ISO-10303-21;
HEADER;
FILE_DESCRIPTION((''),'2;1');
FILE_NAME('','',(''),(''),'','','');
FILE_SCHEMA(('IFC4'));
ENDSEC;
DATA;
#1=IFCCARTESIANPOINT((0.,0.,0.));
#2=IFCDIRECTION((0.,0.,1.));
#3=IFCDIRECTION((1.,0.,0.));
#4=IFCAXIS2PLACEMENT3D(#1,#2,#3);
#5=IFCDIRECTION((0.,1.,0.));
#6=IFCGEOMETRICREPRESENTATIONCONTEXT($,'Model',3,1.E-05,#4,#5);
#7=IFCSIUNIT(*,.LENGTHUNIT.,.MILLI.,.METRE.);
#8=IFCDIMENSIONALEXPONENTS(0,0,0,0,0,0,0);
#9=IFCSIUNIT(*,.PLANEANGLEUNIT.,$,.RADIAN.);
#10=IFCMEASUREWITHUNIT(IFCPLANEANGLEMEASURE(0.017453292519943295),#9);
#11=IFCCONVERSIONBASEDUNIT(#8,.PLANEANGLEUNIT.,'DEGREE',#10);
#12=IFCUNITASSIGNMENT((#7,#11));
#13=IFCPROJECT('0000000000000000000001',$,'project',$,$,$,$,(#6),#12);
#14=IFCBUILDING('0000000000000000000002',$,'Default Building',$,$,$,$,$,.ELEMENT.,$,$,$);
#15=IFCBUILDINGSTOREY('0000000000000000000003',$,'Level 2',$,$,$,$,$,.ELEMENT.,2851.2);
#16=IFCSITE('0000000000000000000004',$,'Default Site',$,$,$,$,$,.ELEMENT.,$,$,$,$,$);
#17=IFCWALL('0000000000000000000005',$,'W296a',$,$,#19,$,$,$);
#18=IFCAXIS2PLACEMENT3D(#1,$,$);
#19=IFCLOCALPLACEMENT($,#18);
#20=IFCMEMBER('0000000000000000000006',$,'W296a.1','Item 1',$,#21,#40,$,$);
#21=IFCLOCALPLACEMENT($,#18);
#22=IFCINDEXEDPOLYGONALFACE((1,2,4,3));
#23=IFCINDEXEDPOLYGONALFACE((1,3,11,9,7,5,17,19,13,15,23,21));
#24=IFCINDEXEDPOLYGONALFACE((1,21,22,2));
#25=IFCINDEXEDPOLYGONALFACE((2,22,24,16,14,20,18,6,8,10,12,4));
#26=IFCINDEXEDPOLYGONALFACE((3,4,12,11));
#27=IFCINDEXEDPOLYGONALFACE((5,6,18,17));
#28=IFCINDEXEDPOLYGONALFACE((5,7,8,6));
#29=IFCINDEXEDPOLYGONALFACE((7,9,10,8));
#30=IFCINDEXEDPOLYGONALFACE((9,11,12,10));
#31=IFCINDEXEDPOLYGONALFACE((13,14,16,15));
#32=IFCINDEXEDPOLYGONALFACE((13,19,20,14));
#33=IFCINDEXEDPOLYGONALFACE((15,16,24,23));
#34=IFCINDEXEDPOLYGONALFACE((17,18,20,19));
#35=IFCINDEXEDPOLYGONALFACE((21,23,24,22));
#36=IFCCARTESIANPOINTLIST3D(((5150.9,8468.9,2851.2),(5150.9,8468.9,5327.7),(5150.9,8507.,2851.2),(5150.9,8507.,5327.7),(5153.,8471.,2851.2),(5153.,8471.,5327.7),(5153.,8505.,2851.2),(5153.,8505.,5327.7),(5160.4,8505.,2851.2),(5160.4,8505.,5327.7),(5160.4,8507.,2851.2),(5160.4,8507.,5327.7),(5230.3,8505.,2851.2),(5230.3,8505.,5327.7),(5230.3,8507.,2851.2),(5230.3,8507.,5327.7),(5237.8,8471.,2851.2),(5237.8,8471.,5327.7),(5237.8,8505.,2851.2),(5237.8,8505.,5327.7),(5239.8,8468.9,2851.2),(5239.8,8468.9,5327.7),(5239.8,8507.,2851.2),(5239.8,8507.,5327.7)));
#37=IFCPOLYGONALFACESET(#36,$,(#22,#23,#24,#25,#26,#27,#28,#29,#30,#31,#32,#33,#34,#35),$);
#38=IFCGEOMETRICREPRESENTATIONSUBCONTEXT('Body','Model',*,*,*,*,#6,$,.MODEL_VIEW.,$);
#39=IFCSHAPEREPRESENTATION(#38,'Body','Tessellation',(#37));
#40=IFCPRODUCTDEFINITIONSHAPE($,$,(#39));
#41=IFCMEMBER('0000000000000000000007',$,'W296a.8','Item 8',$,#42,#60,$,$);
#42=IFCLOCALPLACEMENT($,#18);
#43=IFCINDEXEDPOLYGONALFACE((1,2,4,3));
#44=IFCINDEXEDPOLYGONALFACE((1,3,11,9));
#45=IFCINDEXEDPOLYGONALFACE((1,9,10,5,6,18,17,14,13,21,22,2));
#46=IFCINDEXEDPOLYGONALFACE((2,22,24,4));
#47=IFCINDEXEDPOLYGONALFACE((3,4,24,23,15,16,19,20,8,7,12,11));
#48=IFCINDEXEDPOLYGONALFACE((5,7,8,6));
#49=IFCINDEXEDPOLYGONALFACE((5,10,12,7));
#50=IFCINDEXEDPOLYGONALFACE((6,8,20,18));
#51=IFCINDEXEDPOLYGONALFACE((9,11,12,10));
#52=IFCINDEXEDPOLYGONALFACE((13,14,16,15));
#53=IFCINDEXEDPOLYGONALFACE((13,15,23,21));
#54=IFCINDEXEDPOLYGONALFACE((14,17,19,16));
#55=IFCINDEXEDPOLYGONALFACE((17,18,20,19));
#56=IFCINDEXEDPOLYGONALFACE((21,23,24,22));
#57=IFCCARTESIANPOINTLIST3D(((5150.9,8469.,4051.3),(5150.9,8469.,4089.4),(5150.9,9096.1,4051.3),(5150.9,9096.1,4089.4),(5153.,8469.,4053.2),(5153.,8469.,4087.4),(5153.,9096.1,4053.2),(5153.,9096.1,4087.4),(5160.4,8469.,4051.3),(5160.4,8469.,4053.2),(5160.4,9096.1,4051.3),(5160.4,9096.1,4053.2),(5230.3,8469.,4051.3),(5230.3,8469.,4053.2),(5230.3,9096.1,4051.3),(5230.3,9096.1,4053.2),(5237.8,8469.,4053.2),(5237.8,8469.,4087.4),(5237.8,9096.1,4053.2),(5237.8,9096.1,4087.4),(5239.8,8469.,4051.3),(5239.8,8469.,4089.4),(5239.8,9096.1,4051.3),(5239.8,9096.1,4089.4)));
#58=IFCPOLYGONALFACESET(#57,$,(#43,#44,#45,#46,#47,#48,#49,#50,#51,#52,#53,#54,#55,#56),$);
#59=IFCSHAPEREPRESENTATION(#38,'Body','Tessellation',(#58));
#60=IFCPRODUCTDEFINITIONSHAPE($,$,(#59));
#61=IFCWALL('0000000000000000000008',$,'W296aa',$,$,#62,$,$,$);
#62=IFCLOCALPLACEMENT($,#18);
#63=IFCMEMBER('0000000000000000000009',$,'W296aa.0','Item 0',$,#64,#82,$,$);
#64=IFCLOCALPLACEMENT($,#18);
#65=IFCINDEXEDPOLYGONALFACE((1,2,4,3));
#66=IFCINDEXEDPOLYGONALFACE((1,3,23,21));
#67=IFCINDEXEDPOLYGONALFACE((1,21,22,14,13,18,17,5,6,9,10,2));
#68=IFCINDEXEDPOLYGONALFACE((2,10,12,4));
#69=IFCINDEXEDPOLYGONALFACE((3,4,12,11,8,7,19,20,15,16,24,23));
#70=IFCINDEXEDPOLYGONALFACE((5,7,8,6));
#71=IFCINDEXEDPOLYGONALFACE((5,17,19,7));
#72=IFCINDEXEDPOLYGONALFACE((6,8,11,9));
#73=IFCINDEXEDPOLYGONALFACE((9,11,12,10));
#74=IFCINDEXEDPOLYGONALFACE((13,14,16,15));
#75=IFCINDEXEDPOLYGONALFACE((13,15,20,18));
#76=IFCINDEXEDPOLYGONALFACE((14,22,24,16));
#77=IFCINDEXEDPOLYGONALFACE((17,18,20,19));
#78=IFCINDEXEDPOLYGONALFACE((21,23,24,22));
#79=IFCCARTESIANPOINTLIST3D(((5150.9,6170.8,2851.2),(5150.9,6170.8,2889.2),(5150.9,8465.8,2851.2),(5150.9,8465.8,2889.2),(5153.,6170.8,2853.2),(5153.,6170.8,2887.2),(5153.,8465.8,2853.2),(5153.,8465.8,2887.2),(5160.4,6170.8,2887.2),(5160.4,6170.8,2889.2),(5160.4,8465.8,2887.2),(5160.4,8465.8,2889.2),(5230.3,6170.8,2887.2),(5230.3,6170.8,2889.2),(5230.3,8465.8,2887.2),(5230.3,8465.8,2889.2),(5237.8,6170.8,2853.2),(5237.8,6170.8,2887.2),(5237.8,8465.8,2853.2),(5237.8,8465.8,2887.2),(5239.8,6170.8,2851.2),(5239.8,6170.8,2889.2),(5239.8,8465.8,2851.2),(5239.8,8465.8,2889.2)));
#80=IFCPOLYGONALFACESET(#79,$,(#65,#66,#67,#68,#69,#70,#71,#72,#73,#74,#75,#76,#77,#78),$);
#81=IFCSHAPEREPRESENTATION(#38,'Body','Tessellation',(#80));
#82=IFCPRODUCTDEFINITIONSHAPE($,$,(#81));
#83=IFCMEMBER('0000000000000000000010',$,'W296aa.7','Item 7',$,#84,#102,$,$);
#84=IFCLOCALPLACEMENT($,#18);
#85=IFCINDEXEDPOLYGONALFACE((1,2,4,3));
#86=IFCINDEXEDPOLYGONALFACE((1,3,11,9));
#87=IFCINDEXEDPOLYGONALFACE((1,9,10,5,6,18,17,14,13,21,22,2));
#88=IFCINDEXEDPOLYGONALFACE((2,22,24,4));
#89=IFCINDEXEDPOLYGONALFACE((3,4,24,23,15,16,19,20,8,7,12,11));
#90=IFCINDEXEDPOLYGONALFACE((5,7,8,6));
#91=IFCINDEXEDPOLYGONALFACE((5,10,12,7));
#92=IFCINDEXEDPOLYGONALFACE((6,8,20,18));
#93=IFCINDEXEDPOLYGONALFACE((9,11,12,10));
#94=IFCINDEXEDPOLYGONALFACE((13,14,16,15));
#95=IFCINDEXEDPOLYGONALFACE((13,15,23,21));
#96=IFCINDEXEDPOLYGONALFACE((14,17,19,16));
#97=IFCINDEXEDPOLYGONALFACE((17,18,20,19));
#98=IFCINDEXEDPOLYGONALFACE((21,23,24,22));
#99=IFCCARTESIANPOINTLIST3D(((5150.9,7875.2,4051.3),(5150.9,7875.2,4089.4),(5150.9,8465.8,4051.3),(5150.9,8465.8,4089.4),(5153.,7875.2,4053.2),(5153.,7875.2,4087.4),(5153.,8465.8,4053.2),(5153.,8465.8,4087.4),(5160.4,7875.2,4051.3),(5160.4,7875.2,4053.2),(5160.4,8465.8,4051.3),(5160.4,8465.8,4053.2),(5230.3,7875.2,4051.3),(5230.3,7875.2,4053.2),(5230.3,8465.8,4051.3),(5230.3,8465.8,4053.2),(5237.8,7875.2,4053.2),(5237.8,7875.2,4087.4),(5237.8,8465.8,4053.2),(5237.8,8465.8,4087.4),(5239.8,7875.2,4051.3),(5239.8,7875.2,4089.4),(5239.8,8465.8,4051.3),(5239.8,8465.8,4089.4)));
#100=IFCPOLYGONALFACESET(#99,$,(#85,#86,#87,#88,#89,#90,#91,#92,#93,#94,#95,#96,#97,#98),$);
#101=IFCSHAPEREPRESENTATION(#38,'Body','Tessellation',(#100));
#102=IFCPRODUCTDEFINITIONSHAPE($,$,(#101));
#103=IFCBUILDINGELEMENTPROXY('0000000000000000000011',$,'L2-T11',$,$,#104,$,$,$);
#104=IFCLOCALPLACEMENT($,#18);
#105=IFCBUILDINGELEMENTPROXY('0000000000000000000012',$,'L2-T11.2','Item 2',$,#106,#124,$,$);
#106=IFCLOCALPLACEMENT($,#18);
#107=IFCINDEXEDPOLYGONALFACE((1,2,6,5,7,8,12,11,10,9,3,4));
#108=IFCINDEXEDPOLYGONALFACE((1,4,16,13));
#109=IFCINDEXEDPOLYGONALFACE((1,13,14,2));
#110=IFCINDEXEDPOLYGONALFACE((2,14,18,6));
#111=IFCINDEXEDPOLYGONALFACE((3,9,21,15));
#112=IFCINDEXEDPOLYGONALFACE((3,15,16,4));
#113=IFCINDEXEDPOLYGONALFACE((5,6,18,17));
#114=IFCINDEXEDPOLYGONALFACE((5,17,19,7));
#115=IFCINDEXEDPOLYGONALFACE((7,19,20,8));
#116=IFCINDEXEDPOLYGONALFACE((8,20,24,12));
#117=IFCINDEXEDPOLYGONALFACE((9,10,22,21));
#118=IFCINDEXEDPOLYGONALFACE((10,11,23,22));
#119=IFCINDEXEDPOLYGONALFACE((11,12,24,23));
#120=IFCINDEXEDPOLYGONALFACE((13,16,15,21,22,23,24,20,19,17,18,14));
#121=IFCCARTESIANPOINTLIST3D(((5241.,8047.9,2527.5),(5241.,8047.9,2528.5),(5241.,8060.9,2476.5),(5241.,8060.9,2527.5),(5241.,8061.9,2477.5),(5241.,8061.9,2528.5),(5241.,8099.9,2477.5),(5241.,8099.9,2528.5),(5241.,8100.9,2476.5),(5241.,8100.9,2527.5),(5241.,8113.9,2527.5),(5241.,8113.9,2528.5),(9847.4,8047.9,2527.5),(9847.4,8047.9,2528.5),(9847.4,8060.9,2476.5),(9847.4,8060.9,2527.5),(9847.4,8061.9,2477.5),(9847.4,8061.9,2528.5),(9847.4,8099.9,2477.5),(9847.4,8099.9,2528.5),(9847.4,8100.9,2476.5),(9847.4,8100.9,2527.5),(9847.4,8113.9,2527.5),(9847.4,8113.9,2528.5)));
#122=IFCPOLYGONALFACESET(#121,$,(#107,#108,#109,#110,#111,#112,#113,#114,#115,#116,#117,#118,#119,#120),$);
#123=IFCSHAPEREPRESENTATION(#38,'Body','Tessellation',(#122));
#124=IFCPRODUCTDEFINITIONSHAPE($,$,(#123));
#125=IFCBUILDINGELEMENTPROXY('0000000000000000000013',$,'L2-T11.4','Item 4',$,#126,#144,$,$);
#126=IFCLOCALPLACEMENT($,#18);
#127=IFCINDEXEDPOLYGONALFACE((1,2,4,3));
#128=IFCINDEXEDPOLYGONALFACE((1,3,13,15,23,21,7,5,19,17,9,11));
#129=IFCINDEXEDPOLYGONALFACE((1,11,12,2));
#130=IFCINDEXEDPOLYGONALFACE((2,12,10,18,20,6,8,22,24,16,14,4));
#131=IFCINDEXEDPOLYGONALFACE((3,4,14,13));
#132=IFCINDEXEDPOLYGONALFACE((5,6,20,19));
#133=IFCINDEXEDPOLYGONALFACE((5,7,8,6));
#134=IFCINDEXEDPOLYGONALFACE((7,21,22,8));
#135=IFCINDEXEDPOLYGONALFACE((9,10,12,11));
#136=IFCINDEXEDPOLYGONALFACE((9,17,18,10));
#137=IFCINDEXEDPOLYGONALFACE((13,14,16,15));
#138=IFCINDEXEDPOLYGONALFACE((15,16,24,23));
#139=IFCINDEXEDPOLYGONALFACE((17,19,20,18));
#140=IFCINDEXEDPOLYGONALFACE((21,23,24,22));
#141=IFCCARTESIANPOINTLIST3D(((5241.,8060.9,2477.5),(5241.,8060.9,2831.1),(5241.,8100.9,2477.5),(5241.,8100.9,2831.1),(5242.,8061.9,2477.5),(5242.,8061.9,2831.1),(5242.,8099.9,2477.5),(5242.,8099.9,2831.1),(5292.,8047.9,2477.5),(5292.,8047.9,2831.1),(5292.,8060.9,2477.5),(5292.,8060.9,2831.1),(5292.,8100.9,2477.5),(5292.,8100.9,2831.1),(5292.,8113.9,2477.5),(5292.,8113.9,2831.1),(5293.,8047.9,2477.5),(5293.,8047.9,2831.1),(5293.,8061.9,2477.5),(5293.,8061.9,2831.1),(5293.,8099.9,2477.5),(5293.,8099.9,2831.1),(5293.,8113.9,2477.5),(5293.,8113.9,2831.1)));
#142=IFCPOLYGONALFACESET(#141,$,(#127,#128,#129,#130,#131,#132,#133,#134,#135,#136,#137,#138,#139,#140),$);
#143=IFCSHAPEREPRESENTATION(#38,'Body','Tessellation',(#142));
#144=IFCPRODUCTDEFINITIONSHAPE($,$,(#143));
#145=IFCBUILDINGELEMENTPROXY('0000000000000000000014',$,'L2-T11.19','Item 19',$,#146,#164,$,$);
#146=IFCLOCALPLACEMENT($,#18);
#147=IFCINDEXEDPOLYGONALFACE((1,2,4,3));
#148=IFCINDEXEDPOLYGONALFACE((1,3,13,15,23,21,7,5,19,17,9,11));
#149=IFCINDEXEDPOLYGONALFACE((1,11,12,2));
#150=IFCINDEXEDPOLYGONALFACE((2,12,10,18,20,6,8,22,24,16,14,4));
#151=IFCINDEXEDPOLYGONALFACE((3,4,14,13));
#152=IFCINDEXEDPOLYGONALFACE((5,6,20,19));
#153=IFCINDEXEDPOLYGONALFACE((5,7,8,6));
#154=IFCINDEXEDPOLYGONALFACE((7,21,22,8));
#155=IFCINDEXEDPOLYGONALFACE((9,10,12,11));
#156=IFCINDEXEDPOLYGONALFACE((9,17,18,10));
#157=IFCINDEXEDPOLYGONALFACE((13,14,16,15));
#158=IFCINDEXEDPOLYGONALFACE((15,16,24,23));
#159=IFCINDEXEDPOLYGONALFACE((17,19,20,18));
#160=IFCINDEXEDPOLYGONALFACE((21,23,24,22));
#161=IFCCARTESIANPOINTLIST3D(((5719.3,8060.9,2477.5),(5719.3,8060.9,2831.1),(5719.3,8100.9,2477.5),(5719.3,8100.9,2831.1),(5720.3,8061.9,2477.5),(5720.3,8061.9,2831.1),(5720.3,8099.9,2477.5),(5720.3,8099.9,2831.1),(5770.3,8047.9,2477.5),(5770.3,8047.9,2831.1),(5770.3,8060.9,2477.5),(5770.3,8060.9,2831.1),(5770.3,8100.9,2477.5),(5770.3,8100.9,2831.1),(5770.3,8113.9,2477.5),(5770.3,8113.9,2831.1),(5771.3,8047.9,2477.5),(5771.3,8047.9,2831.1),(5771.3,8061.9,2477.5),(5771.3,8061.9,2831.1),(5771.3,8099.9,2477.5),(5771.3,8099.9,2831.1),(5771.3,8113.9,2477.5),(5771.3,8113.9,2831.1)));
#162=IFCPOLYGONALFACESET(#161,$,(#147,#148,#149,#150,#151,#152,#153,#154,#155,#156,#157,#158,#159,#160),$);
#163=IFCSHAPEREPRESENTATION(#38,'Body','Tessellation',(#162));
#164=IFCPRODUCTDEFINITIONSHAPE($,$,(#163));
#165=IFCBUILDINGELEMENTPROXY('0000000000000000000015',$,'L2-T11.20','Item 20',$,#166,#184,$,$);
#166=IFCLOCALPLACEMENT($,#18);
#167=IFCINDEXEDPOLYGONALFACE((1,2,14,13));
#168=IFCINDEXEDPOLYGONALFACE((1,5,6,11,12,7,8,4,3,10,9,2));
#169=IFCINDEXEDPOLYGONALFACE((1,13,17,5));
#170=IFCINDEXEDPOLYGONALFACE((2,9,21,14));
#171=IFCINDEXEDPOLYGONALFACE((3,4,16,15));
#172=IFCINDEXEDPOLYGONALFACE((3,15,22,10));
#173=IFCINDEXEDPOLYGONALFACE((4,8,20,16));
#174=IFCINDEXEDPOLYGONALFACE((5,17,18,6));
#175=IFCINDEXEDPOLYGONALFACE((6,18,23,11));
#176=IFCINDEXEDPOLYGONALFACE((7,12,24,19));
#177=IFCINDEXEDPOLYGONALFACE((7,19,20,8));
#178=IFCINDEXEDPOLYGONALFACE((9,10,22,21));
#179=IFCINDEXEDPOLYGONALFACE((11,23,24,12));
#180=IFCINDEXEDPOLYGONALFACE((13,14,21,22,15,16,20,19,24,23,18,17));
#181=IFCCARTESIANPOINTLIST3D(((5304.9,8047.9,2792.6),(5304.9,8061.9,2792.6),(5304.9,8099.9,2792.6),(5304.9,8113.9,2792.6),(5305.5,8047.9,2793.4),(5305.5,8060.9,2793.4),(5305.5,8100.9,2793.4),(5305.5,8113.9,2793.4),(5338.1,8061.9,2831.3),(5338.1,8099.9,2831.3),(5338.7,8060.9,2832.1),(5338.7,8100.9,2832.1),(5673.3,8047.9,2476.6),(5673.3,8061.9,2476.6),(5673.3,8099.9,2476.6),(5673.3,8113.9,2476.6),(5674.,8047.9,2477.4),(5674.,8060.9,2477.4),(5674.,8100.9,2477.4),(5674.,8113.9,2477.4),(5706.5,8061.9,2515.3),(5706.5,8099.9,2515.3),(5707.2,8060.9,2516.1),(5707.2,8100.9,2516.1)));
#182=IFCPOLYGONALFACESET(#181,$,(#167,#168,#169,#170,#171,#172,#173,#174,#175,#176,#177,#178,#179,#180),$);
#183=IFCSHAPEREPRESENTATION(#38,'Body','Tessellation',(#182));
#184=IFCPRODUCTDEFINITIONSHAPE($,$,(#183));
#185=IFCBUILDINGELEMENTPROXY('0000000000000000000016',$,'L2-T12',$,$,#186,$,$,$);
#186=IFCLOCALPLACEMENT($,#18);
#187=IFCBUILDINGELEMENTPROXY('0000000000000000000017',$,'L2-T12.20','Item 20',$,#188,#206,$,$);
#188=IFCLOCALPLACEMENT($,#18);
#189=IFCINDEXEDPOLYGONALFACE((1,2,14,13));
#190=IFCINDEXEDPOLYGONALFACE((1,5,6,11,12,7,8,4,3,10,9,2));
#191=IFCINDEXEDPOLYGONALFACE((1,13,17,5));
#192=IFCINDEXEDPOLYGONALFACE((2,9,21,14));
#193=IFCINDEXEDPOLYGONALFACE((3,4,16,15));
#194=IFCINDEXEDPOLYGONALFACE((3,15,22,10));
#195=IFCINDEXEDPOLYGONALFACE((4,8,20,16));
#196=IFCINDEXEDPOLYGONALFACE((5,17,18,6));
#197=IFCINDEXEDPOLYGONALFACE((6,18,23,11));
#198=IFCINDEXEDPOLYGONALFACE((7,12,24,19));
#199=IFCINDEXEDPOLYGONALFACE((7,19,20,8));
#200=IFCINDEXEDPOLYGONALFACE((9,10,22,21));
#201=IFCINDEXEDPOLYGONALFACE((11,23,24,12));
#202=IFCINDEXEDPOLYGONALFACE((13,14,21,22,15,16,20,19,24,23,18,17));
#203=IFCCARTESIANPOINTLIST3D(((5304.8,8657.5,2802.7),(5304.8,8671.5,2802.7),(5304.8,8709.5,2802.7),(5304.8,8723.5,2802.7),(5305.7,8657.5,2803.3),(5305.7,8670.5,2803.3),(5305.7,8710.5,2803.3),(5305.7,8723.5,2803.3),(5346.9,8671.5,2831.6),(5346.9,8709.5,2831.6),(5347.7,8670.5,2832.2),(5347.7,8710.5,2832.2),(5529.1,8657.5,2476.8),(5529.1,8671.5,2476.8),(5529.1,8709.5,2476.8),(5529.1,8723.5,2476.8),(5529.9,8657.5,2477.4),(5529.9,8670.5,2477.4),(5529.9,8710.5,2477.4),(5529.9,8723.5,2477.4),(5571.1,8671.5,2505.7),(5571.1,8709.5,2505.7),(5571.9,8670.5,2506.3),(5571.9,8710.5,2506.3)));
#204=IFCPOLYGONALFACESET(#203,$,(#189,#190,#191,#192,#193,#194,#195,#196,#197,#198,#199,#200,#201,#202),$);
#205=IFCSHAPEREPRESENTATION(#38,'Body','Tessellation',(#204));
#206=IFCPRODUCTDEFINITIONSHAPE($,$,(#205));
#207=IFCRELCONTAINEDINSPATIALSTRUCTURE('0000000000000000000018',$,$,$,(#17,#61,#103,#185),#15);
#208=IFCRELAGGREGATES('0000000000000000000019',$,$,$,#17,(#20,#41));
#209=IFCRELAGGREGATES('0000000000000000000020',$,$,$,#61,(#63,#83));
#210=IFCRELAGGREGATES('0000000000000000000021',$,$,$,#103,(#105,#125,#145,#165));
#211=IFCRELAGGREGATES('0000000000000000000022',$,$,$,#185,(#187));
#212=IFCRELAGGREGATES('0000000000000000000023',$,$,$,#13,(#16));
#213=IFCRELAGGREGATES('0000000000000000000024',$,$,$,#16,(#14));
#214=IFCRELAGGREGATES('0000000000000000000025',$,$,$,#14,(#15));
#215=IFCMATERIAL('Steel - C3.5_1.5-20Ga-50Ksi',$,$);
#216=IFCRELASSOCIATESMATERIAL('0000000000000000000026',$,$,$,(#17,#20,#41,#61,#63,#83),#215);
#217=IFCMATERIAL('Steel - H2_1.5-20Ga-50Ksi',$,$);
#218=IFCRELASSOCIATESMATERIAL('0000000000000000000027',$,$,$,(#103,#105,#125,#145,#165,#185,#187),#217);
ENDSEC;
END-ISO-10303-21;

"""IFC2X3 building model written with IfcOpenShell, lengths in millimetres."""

from ifc_helpers import new_model, entity, si_unit, converted_unit, direction, frame, origin, origin_with_axes, origin_2d_with_axis, place, context, subcontext, project, spatial, polyline, c_section, outline, extrude, material, element, aggregate, save


model = new_model("IFC2X3")

# Units and contexts
model_context = context("Model", 3, precision=1e-05, world=origin_with_axes(), true_north=direction((0.0, 1.0, 0.0)))
body_context = subcontext(model_context, "Body", "Model", "MODEL_VIEW")
ifc_project = project(units=[si_unit("LENGTHUNIT", "METRE", prefix="MILLI"), converted_unit("PLANEANGLEUNIT", "DEGREE", entity("IfcPlaneAngleMeasure", 0.017453292519943295), si_unit("PLANEANGLEUNIT", "RADIAN"), dimensions=[0, 0, 0, 0, 0, 0, 0])], contexts=[model_context])

# Site, building, storey
site = spatial("IfcSite", under=ifc_project, Name="Default Site", CompositionType="ELEMENT")
building = spatial("IfcBuilding", under=site, Name="Default Building", CompositionType="ELEMENT")
storey = spatial("IfcBuildingStorey", under=building, Name="Level 2", CompositionType="ELEMENT", Elevation=2851.2)

# Walls, members
ifc_material_1 = material(Name="Steel - C3.5_1.5-20Ga-50Ksi")
wall_1 = element("IfcWall", 1, inside=storey, material=ifc_material_1, Name="W296a")
member_1_placement = place(None, frame((5195.4, 8488.0, 2851.2), z_axis=(0.0, 0.0, 1.0), x_axis=(0.0, 1.0, 0.0)))
member_1 = element("IfcMember", 2, at=member_1_placement, material=ifc_material_1, Name="W296a.1", Description="Item 1", context=body_context, shape_type="SweptSolid", body=[
    extrude(c_section(Depth=88.9, Width=38.1, WallThickness=2.0, Girth=9.5, at=origin_2d_with_axis()), origin(), (0.0, 0.0, 1.0), 2476.5),
])
member_2_placement = place(None, frame((5195.4, 8469.0, 4070.3), z_axis=(0.0, 1.0, 0.0), x_axis=(0.0, 0.0, -1.0)))
member_2 = element("IfcMember", 3, at=member_2_placement, material=ifc_material_1, Name="W296a.8", Description="Item 8", context=body_context, shape_type="SweptSolid", body=[
    extrude(c_section(Depth=88.9, Width=38.1, WallThickness=2.0, Girth=9.5, at=origin_2d_with_axis()), origin(), (0.0, 0.0, 1.0), 627.1),
])
aggregate(wall_1, [member_1, member_2])
wall_2 = element("IfcWall", 4, inside=storey, material=ifc_material_1, Name="W296aa")
member_3_placement = place(None, frame((5195.4, 8465.8, 2870.2), z_axis=(0.0, -1.0, 0.0), x_axis=(0.0, 0.0, 1.0)))
member_3 = element("IfcMember", 5, at=member_3_placement, material=ifc_material_1, Name="W296aa.0", Description="Item 0", context=body_context, shape_type="SweptSolid", body=[
    extrude(c_section(Depth=88.9, Width=38.1, WallThickness=2.0, Girth=9.5, at=origin_2d_with_axis()), origin(), (0.0, 0.0, 1.0), 2295.0),
])
member_4_placement = place(None, frame((5195.4, 7875.2, 4070.3), z_axis=(0.0, 1.0, 0.0), x_axis=(0.0, 0.0, -1.0)))
member_4 = element("IfcMember", 6, at=member_4_placement, material=ifc_material_1, Name="W296aa.7", Description="Item 7", context=body_context, shape_type="SweptSolid", body=[
    extrude(c_section(Depth=88.9, Width=38.1, WallThickness=2.0, Girth=9.5, at=origin_2d_with_axis()), origin(), (0.0, 0.0, 1.0), 590.6),
])
aggregate(wall_2, [member_3, member_4])

# Building element proxies
ifc_material_2 = material(Name="Steel - H2_1.5-20Ga-50Ksi")
proxy_1 = element("IfcBuildingElementProxy", 7, inside=storey, material=ifc_material_2, Name="L2-T11")
proxy_2_placement = place(None, frame((5241.0, 8113.9, 2528.5), z_axis=(1.0, 0.0, 0.0), x_axis=(0.0, -40.0, 0.0)))
proxy_2 = element("IfcBuildingElementProxy", 8, at=proxy_2_placement, material=ifc_material_2, Name="L2-T11.2", Description="Item 2", context=body_context, shape_type="SweptSolid", body=[
    extrude(outline(polyline([(0.0, 0.0), (14.0, 0.0), (14.0, 51.0), (52.0, 51.0), (52.0, 0.0), (66.0, 0.0), (66.0, 1.0), (53.0, 1.0), (53.0, 52.0), (13.0, 52.0), (13.0, 1.0), (0.0, 1.0), (0.0, 0.0)])), origin(), (0.0, 0.0, 1.0), 4606.4),
])
proxy_3_placement = place(None, frame((5293.0, 8113.9, 2831.1), z_axis=(0.0, 0.0, -1.0), x_axis=(0.0, -40.0, 0.0)))
proxy_3 = element("IfcBuildingElementProxy", 9, at=proxy_3_placement, material=ifc_material_2, Name="L2-T11.4", Description="Item 4", context=body_context, shape_type="SweptSolid", body=[
    extrude(outline(polyline([(0.0, 0.0), (14.0, 0.0), (14.0, 51.0), (52.0, 51.0), (52.0, 0.0), (66.0, 0.0), (66.0, 1.0), (53.0, 1.0), (53.0, 52.0), (13.0, 52.0), (13.0, 1.0), (0.0, 1.0), (0.0, 0.0)])), origin(), (0.0, 0.0, 1.0), 353.6),
])
proxy_4_placement = place(None, frame((5771.3, 8113.9, 2831.1), z_axis=(0.0, 0.0, -1.0), x_axis=(0.0, -40.0, 0.0)))
proxy_4 = element("IfcBuildingElementProxy", 10, at=proxy_4_placement, material=ifc_material_2, Name="L2-T11.19", Description="Item 19", context=body_context, shape_type="SweptSolid", body=[
    extrude(outline(polyline([(0.0, 0.0), (14.0, 0.0), (14.0, 51.0), (52.0, 51.0), (52.0, 0.0), (66.0, 0.0), (66.0, 1.0), (53.0, 1.0), (53.0, 52.0), (13.0, 52.0), (13.0, 1.0), (0.0, 1.0), (0.0, 0.0)])), origin(), (0.0, 0.0, 1.0), 353.6),
])
proxy_5_placement = place(None, frame((5673.3, 8113.9, 2476.6), z_axis=(-0.759, 0.0, 0.651), x_axis=(0.0, -40.0, 0.0)))
proxy_5 = element("IfcBuildingElementProxy", 11, at=proxy_5_placement, material=ifc_material_2, Name="L2-T11.20", Description="Item 20", context=body_context, shape_type="SweptSolid", body=[
    extrude(outline(polyline([(0.0, 0.0), (14.0, 0.0), (14.0, 51.0), (52.0, 51.0), (52.0, 0.0), (66.0, 0.0), (66.0, 1.0), (53.0, 1.0), (53.0, 52.0), (13.0, 52.0), (13.0, 1.0), (0.0, 1.0), (0.0, 0.0)])), origin(), (0.0, 0.0, 1.0), 485.4),
])
aggregate(proxy_1, [proxy_2, proxy_3, proxy_4, proxy_5])
proxy_6 = element("IfcBuildingElementProxy", 12, inside=storey, material=ifc_material_2, Name="L2-T12")
proxy_7_placement = place(None, frame((5529.1, 8723.5, 2476.8), z_axis=(-0.567, 0.0, 0.824), x_axis=(0.0, -40.0, 0.0)))
proxy_7 = element("IfcBuildingElementProxy", 13, at=proxy_7_placement, material=ifc_material_2, Name="L2-T12.20", Description="Item 20", context=body_context, shape_type="SweptSolid", body=[
    extrude(outline(polyline([(0.0, 0.0), (14.0, 0.0), (14.0, 51.0), (52.0, 51.0), (52.0, 0.0), (66.0, 0.0), (66.0, 1.0), (53.0, 1.0), (53.0, 52.0), (13.0, 52.0), (13.0, 1.0), (0.0, 1.0), (0.0, 0.0)])), origin(), (0.0, 0.0, 1.0), 395.6),
])
aggregate(proxy_6, [proxy_7])

save(model, "model.ifc")
